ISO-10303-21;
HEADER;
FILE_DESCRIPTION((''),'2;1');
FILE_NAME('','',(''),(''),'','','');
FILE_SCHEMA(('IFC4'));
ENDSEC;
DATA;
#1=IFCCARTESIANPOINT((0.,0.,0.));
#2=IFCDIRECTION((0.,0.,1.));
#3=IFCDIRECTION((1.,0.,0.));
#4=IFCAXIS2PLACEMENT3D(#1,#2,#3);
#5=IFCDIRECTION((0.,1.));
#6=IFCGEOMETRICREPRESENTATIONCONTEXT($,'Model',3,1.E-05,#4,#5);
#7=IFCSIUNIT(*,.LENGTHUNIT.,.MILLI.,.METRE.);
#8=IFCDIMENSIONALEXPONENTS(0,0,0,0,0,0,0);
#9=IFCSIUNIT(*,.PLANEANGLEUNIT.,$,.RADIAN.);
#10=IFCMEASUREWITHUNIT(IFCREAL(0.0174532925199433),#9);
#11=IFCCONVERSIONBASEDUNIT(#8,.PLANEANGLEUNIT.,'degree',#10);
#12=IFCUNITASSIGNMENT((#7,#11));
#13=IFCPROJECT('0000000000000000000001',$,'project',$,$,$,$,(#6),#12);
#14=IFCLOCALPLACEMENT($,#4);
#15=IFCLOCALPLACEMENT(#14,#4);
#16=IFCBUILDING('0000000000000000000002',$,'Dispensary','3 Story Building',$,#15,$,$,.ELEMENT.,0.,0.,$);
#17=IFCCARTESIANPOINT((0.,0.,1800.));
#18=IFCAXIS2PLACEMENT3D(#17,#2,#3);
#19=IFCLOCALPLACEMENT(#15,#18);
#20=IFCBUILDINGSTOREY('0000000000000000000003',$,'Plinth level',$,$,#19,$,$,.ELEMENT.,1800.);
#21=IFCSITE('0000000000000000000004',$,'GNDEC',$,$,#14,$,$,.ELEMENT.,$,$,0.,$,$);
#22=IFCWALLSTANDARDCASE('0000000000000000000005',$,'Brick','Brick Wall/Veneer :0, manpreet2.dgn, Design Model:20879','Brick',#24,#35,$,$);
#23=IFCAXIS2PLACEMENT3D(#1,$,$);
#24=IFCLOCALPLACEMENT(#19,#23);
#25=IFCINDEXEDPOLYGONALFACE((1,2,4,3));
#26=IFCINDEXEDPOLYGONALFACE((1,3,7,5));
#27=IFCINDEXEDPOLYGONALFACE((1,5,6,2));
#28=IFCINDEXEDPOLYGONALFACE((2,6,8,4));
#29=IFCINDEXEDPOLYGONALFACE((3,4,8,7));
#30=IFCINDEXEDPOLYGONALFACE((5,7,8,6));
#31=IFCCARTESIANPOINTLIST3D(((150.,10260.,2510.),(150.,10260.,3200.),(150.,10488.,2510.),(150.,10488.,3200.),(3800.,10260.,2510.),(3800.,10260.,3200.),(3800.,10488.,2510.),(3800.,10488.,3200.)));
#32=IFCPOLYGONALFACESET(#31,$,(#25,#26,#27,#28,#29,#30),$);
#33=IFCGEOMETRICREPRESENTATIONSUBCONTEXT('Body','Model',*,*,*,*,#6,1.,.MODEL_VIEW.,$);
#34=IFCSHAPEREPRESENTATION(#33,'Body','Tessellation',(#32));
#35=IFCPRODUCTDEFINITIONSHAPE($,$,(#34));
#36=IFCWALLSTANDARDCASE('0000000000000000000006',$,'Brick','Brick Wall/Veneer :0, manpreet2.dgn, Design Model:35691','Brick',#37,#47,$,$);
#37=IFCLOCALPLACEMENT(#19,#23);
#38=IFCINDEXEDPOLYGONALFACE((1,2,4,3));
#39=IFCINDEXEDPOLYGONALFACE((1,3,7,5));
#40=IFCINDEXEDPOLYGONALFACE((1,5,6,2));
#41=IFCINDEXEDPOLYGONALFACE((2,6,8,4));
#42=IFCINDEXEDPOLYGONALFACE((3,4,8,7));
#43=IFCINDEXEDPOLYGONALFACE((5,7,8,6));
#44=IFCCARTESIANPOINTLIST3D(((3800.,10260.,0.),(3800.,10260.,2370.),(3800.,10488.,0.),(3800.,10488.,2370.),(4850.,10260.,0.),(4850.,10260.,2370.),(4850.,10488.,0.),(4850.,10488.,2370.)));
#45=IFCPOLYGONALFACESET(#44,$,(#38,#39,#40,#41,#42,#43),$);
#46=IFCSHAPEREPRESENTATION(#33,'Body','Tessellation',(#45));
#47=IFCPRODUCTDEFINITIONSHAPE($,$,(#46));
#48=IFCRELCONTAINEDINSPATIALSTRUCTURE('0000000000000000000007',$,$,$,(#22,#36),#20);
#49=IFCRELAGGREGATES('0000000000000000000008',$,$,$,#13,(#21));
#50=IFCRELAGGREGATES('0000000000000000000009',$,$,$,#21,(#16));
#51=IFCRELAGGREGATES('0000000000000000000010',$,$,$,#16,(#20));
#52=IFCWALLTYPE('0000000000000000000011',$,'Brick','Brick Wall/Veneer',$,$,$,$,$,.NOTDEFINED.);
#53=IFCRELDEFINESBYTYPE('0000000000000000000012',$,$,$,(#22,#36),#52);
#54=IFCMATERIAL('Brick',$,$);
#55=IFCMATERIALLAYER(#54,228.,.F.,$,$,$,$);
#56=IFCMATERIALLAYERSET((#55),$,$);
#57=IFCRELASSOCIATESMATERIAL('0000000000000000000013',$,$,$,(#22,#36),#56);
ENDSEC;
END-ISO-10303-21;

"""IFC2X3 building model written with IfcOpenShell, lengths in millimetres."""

from ifc_helpers import new_model, entity, si_unit, converted_unit, direction, frame, frame_2d, origin_with_axes, place, context, subcontext, project, spatial, rectangle, extrude, material, layer, layer_set, layer_usage, type_object, element, save


model = new_model("IFC2X3")

# Units and contexts
model_context = context("Model", 3, precision=1e-05, world=origin_with_axes(), true_north=direction((0.0, 1.0)))
body_context = subcontext(model_context, "Body", "Model", "MODEL_VIEW", scale=1.0)
ifc_project = project(units=[si_unit("LENGTHUNIT", "METRE", prefix="MILLI"), converted_unit("PLANEANGLEUNIT", "degree", entity("IfcReal", 0.0174532925199433), si_unit("PLANEANGLEUNIT", "RADIAN"), dimensions=[0, 0, 0, 0, 0, 0, 0])], contexts=[model_context])

# Site, building, storey
site_placement = place(None, origin_with_axes())
site = spatial("IfcSite", under=ifc_project, at=site_placement, Name="GNDEC", CompositionType="ELEMENT", RefElevation=0.0)
building_placement = place(site_placement, origin_with_axes())
building = spatial("IfcBuilding", under=site, at=building_placement, Name="Dispensary", Description="3 Story Building", CompositionType="ELEMENT", ElevationOfRefHeight=0.0, ElevationOfTerrain=0.0)
storey_placement = place(building_placement, frame((0.0, 0.0, 1800.0), z_axis=(0.0, 0.0, 1.0), x_axis=(1.0, 0.0, 0.0)))
storey = spatial("IfcBuildingStorey", under=building, at=storey_placement, Name="Plinth level", CompositionType="ELEMENT", Elevation=1800.0)

# Shared definitions
ifc_material_1 = material(Name="Brick")
ifc_layer = layer(ifc_material_1, 228.0, ventilated=False)
ifc_layer_set = layer_set([ifc_layer])
ifc_layer_usage = layer_usage(ifc_layer_set, "AXIS2", "POSITIVE", 0.0)
wall_type = type_object("IfcWallType", Name="Brick", Description="Brick Wall/Veneer", PredefinedType="NOTDEFINED")

# Walls
wall_1_placement = place(storey_placement, frame((3800.0, 10260.0, 2510.0), z_axis=(0.0, 0.0, 1.0), x_axis=(-1.0, 0.0, 0.0)))
element("IfcWallStandardCase", 1, at=wall_1_placement, inside=storey, type_object=wall_type, material=ifc_layer_usage, Name="Brick", Description="Brick Wall/Veneer :0, manpreet2.dgn, Design Model:20879", ObjectType="Brick", context=body_context, shape_type="SweptSolid", body=[
    extrude(rectangle(XDim=3650.0, YDim=228.0, at=frame_2d((1825.0, -114.0), x_axis=(-1.0, 0.0))), origin_with_axes(), (0.0, 0.0, 1.0), 690.0),
])
wall_2_placement = place(storey_placement, frame((4850.0, 10260.0, 0.0), z_axis=(0.0, 0.0, 1.0), x_axis=(-1.0, 0.0, 0.0)))
element("IfcWallStandardCase", 2, at=wall_2_placement, inside=storey, type_object=wall_type, material=ifc_layer_usage, Name="Brick", Description="Brick Wall/Veneer :0, manpreet2.dgn, Design Model:35691", ObjectType="Brick", context=body_context, shape_type="SweptSolid", body=[
    extrude(rectangle(XDim=1050.0, YDim=228.0, at=frame_2d((525.0, -114.0), x_axis=(-1.0, 0.0))), origin_with_axes(), (0.0, 0.0, 1.0), 2370.0),
])

save(model, "model.ifc")
